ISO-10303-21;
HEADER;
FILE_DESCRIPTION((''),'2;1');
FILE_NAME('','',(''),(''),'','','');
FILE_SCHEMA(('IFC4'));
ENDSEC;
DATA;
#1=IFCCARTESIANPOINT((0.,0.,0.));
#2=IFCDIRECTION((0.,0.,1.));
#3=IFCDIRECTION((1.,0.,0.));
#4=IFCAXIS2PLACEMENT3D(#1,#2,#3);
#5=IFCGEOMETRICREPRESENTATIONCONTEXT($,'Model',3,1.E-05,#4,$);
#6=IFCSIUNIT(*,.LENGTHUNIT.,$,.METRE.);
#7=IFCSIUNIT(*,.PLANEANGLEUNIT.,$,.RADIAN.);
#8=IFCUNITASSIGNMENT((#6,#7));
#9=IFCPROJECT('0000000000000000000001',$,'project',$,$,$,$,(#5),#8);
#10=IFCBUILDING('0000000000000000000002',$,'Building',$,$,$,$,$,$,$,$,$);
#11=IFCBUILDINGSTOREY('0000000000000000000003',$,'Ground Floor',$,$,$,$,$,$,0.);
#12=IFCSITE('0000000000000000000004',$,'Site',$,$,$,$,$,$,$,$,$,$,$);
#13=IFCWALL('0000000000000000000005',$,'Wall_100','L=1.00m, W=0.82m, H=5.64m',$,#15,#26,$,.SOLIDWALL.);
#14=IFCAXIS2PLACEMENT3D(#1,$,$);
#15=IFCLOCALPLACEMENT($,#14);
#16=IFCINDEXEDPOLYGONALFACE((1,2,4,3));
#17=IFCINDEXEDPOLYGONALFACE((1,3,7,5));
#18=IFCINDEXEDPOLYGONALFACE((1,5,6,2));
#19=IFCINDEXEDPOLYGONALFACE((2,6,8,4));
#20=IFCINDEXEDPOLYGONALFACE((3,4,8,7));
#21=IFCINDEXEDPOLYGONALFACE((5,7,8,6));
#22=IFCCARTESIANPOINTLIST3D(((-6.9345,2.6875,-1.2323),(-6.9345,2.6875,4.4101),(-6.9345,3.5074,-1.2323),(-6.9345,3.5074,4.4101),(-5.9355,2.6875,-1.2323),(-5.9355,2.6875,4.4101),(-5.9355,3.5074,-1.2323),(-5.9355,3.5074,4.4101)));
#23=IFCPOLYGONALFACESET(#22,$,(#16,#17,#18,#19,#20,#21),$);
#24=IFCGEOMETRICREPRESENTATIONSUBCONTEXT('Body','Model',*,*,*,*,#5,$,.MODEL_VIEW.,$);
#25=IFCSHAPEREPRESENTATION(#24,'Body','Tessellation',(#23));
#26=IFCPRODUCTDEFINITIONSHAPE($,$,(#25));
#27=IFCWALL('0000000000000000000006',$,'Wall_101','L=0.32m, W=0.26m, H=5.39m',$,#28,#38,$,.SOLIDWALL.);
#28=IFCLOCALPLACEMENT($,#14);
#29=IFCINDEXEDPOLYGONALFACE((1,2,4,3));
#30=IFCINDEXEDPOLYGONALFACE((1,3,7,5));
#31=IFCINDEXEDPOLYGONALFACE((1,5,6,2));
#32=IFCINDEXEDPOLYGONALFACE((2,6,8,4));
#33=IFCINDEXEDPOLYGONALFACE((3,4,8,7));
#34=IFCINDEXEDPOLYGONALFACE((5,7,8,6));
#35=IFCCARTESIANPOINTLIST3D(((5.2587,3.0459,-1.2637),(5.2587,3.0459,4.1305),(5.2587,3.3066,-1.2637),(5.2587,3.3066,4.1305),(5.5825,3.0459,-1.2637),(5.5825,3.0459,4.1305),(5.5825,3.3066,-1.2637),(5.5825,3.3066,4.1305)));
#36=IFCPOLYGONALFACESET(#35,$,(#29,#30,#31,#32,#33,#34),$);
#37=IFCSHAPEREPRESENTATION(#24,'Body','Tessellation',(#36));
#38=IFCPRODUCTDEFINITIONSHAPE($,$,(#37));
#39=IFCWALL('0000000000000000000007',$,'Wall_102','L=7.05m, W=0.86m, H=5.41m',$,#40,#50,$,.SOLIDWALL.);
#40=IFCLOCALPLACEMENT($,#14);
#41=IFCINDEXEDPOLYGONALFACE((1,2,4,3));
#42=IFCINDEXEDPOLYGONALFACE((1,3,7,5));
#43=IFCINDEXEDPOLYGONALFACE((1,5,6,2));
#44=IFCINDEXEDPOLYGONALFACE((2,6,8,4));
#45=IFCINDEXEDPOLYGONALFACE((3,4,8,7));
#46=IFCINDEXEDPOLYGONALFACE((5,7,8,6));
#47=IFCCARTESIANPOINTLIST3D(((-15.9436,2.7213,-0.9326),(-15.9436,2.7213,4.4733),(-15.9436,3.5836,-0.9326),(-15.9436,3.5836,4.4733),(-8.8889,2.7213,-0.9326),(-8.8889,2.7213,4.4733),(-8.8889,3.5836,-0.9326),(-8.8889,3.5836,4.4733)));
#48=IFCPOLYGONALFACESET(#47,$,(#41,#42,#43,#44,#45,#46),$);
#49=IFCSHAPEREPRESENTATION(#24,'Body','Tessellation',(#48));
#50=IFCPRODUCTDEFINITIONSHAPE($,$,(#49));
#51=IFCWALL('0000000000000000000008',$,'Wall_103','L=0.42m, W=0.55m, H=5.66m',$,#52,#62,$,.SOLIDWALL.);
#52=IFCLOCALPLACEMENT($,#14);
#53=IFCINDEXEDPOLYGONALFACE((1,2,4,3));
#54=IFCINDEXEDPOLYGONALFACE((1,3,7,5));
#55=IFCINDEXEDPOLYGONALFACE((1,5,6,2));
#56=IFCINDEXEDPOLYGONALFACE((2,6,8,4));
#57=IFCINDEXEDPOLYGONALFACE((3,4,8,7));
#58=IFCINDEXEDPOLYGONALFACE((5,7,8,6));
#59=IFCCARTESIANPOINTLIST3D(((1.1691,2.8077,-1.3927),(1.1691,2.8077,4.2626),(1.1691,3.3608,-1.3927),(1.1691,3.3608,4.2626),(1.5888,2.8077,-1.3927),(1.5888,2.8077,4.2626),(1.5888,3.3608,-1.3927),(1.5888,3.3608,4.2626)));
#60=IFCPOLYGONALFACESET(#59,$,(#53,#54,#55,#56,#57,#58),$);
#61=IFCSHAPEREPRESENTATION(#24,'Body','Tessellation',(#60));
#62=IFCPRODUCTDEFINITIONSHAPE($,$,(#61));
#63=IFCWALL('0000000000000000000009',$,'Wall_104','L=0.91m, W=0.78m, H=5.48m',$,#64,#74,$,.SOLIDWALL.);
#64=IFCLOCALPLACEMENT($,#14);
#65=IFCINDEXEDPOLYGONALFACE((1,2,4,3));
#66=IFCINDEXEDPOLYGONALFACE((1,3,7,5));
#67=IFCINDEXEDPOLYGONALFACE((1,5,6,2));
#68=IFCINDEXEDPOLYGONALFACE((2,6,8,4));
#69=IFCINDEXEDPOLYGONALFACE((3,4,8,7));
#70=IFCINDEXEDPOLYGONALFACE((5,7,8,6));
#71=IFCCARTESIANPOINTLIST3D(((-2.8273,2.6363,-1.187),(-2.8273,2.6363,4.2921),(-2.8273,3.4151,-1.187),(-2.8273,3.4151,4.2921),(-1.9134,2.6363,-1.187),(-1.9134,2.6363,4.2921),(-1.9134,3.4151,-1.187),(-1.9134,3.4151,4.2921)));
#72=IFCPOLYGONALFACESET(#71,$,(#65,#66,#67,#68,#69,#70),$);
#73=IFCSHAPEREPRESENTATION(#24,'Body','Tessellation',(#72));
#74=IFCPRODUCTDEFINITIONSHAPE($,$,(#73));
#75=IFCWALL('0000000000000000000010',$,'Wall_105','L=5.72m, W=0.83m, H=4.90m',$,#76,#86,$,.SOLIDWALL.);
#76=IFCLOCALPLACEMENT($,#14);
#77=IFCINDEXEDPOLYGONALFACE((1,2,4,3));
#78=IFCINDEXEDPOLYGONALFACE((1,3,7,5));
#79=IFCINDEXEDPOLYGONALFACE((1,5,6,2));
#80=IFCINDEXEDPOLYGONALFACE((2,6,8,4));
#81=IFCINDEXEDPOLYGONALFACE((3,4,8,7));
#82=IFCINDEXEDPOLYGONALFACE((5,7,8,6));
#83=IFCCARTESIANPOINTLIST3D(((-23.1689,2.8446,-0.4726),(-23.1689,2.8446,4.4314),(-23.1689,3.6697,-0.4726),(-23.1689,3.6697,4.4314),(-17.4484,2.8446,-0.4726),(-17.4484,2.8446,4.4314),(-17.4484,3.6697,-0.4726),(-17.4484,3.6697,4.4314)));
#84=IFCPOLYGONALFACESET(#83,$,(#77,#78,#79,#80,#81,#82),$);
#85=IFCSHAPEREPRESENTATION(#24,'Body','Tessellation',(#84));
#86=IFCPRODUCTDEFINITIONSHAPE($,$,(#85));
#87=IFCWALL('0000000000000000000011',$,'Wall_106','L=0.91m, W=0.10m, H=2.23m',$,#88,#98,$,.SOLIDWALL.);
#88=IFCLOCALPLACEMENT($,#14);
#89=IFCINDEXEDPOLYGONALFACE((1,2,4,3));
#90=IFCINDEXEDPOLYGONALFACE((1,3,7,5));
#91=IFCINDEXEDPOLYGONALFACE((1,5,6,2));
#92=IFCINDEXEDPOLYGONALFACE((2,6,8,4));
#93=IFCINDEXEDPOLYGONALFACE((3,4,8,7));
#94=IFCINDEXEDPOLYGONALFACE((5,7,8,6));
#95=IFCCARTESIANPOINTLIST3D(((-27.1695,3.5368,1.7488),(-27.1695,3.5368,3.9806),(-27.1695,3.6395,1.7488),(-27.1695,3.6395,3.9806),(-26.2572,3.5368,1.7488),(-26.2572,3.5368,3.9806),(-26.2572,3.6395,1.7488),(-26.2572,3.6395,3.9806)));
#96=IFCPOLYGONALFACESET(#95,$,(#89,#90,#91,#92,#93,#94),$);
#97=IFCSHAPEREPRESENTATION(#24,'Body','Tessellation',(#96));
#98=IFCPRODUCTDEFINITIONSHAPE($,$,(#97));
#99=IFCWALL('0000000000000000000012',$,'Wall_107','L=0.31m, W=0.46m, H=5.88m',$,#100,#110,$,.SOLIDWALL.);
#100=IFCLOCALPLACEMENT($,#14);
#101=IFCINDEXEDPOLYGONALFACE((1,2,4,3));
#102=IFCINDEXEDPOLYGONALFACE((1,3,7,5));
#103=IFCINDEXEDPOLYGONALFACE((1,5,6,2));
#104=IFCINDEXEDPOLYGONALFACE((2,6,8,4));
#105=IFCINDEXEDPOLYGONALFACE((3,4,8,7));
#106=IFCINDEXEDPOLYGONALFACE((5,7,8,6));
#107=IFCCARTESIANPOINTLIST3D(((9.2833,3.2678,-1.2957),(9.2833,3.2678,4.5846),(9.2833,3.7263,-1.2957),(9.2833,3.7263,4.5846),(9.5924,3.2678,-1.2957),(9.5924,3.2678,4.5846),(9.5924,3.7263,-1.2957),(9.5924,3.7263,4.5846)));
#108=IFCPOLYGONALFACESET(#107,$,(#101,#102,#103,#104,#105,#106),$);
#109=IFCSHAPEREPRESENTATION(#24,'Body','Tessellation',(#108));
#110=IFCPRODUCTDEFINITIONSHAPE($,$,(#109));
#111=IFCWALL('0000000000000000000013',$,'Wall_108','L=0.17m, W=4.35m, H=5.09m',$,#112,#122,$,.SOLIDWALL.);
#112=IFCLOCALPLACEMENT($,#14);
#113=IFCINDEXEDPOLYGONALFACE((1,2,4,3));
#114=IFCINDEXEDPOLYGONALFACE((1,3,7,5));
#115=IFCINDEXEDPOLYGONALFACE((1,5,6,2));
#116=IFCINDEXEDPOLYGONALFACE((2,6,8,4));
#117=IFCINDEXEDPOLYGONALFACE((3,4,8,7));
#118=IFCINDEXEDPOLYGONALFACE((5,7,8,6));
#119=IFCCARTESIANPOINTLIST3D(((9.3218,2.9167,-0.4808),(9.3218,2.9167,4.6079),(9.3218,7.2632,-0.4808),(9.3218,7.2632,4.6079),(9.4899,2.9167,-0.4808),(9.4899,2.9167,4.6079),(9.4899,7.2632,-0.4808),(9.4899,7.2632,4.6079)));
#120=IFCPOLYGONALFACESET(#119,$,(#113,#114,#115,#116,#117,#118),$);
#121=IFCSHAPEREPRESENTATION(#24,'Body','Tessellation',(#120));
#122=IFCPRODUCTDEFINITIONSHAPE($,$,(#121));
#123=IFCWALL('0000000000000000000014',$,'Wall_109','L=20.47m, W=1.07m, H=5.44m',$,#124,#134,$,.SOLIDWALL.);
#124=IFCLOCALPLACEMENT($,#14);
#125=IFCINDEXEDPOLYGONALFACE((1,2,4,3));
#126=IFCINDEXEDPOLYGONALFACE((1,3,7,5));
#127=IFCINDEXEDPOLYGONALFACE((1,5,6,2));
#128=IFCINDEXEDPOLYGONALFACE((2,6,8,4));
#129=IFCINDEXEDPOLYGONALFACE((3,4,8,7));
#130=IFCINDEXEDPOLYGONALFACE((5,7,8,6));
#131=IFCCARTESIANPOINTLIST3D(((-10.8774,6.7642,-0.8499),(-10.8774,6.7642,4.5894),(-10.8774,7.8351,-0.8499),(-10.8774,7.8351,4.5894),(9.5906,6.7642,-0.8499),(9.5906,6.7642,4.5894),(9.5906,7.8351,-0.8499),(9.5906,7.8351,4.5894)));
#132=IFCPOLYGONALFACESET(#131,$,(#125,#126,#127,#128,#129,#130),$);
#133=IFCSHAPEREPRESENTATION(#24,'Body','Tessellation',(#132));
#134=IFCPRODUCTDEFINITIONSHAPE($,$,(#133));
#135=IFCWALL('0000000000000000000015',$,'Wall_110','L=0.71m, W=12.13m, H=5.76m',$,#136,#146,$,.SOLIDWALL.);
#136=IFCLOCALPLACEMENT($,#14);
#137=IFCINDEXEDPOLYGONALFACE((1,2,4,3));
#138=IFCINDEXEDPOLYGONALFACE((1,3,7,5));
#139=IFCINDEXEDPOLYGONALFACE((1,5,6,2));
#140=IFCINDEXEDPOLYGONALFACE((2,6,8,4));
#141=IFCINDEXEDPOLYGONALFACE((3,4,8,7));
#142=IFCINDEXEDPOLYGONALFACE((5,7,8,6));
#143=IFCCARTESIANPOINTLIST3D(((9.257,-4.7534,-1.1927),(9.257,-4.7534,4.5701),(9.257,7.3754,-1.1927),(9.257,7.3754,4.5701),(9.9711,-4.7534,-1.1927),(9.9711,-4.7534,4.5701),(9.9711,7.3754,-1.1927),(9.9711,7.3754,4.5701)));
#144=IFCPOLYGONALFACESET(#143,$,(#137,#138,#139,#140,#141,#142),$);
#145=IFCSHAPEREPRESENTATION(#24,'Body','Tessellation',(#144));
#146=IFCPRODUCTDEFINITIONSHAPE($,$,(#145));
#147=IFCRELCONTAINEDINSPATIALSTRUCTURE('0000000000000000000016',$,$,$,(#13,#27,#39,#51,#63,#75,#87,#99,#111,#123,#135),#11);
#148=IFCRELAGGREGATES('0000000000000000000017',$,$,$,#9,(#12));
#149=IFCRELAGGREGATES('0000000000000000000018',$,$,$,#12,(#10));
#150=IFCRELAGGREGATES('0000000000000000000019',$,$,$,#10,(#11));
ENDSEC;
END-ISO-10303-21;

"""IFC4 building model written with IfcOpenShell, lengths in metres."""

from ifc_helpers import new_model, si_unit, frame, origin_with_axes, origin_2d, context, subcontext, project, spatial, rectangle, extrude, element, save


model = new_model("IFC4")

# Units and contexts
model_context = context("Model", 3, precision=1e-05, world=origin_with_axes())
body_context = subcontext(model_context, "Body", "Model", "MODEL_VIEW")
ifc_project = project(units=[si_unit("LENGTHUNIT", "METRE"), si_unit("PLANEANGLEUNIT", "RADIAN")], contexts=[model_context])

# Site, building, storey
site = spatial("IfcSite", under=ifc_project, Name="Site")
building = spatial("IfcBuilding", under=site, Name="Building")
storey = spatial("IfcBuildingStorey", under=building, Name="Ground Floor", Elevation=0.0)

# Walls
element("IfcWall", 1, inside=storey, Name="Wall_100", Description="L=1.00m, W=0.82m, H=5.64m", PredefinedType="SOLIDWALL", context=body_context, shape_type="SweptSolid", body=[
    extrude(rectangle(XDim=0.999, YDim=0.8198, at=origin_2d()), frame((-6.435, 3.0974, -1.2323), z_axis=(0.0, 0.0, 1.0), x_axis=(1.0, 0.0, 0.0)), (0.0, 0.0, 1.0), 5.6424),
])
element("IfcWall", 2, inside=storey, Name="Wall_101", Description="L=0.32m, W=0.26m, H=5.39m", PredefinedType="SOLIDWALL", context=body_context, shape_type="SweptSolid", body=[
    extrude(rectangle(XDim=0.3237, YDim=0.2606, at=origin_2d()), frame((5.4206, 3.1763, -1.2637), z_axis=(0.0, 0.0, 1.0), x_axis=(1.0, 0.0, 0.0)), (0.0, 0.0, 1.0), 5.3941),
])
element("IfcWall", 3, inside=storey, Name="Wall_102", Description="L=7.05m, W=0.86m, H=5.41m", PredefinedType="SOLIDWALL", context=body_context, shape_type="SweptSolid", body=[
    extrude(rectangle(XDim=7.0547, YDim=0.8623, at=origin_2d()), frame((-12.4163, 3.1524, -0.9326), z_axis=(0.0, 0.0, 1.0), x_axis=(1.0, 0.0, 0.0)), (0.0, 0.0, 1.0), 5.4059),
])
element("IfcWall", 4, inside=storey, Name="Wall_103", Description="L=0.42m, W=0.55m, H=5.66m", PredefinedType="SOLIDWALL", context=body_context, shape_type="SweptSolid", body=[
    extrude(rectangle(XDim=0.4197, YDim=0.5531, at=origin_2d()), frame((1.379, 3.0842, -1.3927), z_axis=(0.0, 0.0, 1.0), x_axis=(1.0, 0.0, 0.0)), (0.0, 0.0, 1.0), 5.6553),
])
element("IfcWall", 5, inside=storey, Name="Wall_104", Description="L=0.91m, W=0.78m, H=5.48m", PredefinedType="SOLIDWALL", context=body_context, shape_type="SweptSolid", body=[
    extrude(rectangle(XDim=0.9138, YDim=0.7788, at=origin_2d()), frame((-2.3703, 3.0257, -1.187), z_axis=(0.0, 0.0, 1.0), x_axis=(1.0, 0.0, 0.0)), (0.0, 0.0, 1.0), 5.4791),
])
element("IfcWall", 6, inside=storey, Name="Wall_105", Description="L=5.72m, W=0.83m, H=4.90m", PredefinedType="SOLIDWALL", context=body_context, shape_type="SweptSolid", body=[
    extrude(rectangle(XDim=5.7205, YDim=0.8251, at=origin_2d()), frame((-20.3086, 3.2571, -0.4726), z_axis=(0.0, 0.0, 1.0), x_axis=(1.0, 0.0, 0.0)), (0.0, 0.0, 1.0), 4.9039),
])
element("IfcWall", 7, inside=storey, Name="Wall_106", Description="L=0.91m, W=0.10m, H=2.23m", PredefinedType="SOLIDWALL", context=body_context, shape_type="SweptSolid", body=[
    extrude(rectangle(XDim=0.9124, YDim=0.1028, at=origin_2d()), frame((-26.7134, 3.5881, 1.7488), z_axis=(0.0, 0.0, 1.0), x_axis=(1.0, 0.0, 0.0)), (0.0, 0.0, 1.0), 2.2317),
])
element("IfcWall", 8, inside=storey, Name="Wall_107", Description="L=0.31m, W=0.46m, H=5.88m", PredefinedType="SOLIDWALL", context=body_context, shape_type="SweptSolid", body=[
    extrude(rectangle(XDim=0.3092, YDim=0.4585, at=origin_2d()), frame((9.4379, 3.497, -1.2957), z_axis=(0.0, 0.0, 1.0), x_axis=(1.0, 0.0, 0.0)), (0.0, 0.0, 1.0), 5.8803),
])
element("IfcWall", 9, inside=storey, Name="Wall_108", Description="L=0.17m, W=4.35m, H=5.09m", PredefinedType="SOLIDWALL", context=body_context, shape_type="SweptSolid", body=[
    extrude(rectangle(XDim=0.1681, YDim=4.3465, at=origin_2d()), frame((9.4059, 5.09, -0.4808), z_axis=(0.0, 0.0, 1.0), x_axis=(1.0, 0.0, 0.0)), (0.0, 0.0, 1.0), 5.0886),
])
element("IfcWall", 10, inside=storey, Name="Wall_109", Description="L=20.47m, W=1.07m, H=5.44m", PredefinedType="SOLIDWALL", context=body_context, shape_type="SweptSolid", body=[
    extrude(rectangle(XDim=20.468, YDim=1.0709, at=origin_2d()), frame((-0.6434, 7.2996, -0.8499), z_axis=(0.0, 0.0, 1.0), x_axis=(1.0, 0.0, 0.0)), (0.0, 0.0, 1.0), 5.4393),
])
element("IfcWall", 11, inside=storey, Name="Wall_110", Description="L=0.71m, W=12.13m, H=5.76m", PredefinedType="SOLIDWALL", context=body_context, shape_type="SweptSolid", body=[
    extrude(rectangle(XDim=0.7141, YDim=12.1288, at=origin_2d()), frame((9.614, 1.311, -1.1927), z_axis=(0.0, 0.0, 1.0), x_axis=(1.0, 0.0, 0.0)), (0.0, 0.0, 1.0), 5.7628),
])

save(model, "model.ifc")
